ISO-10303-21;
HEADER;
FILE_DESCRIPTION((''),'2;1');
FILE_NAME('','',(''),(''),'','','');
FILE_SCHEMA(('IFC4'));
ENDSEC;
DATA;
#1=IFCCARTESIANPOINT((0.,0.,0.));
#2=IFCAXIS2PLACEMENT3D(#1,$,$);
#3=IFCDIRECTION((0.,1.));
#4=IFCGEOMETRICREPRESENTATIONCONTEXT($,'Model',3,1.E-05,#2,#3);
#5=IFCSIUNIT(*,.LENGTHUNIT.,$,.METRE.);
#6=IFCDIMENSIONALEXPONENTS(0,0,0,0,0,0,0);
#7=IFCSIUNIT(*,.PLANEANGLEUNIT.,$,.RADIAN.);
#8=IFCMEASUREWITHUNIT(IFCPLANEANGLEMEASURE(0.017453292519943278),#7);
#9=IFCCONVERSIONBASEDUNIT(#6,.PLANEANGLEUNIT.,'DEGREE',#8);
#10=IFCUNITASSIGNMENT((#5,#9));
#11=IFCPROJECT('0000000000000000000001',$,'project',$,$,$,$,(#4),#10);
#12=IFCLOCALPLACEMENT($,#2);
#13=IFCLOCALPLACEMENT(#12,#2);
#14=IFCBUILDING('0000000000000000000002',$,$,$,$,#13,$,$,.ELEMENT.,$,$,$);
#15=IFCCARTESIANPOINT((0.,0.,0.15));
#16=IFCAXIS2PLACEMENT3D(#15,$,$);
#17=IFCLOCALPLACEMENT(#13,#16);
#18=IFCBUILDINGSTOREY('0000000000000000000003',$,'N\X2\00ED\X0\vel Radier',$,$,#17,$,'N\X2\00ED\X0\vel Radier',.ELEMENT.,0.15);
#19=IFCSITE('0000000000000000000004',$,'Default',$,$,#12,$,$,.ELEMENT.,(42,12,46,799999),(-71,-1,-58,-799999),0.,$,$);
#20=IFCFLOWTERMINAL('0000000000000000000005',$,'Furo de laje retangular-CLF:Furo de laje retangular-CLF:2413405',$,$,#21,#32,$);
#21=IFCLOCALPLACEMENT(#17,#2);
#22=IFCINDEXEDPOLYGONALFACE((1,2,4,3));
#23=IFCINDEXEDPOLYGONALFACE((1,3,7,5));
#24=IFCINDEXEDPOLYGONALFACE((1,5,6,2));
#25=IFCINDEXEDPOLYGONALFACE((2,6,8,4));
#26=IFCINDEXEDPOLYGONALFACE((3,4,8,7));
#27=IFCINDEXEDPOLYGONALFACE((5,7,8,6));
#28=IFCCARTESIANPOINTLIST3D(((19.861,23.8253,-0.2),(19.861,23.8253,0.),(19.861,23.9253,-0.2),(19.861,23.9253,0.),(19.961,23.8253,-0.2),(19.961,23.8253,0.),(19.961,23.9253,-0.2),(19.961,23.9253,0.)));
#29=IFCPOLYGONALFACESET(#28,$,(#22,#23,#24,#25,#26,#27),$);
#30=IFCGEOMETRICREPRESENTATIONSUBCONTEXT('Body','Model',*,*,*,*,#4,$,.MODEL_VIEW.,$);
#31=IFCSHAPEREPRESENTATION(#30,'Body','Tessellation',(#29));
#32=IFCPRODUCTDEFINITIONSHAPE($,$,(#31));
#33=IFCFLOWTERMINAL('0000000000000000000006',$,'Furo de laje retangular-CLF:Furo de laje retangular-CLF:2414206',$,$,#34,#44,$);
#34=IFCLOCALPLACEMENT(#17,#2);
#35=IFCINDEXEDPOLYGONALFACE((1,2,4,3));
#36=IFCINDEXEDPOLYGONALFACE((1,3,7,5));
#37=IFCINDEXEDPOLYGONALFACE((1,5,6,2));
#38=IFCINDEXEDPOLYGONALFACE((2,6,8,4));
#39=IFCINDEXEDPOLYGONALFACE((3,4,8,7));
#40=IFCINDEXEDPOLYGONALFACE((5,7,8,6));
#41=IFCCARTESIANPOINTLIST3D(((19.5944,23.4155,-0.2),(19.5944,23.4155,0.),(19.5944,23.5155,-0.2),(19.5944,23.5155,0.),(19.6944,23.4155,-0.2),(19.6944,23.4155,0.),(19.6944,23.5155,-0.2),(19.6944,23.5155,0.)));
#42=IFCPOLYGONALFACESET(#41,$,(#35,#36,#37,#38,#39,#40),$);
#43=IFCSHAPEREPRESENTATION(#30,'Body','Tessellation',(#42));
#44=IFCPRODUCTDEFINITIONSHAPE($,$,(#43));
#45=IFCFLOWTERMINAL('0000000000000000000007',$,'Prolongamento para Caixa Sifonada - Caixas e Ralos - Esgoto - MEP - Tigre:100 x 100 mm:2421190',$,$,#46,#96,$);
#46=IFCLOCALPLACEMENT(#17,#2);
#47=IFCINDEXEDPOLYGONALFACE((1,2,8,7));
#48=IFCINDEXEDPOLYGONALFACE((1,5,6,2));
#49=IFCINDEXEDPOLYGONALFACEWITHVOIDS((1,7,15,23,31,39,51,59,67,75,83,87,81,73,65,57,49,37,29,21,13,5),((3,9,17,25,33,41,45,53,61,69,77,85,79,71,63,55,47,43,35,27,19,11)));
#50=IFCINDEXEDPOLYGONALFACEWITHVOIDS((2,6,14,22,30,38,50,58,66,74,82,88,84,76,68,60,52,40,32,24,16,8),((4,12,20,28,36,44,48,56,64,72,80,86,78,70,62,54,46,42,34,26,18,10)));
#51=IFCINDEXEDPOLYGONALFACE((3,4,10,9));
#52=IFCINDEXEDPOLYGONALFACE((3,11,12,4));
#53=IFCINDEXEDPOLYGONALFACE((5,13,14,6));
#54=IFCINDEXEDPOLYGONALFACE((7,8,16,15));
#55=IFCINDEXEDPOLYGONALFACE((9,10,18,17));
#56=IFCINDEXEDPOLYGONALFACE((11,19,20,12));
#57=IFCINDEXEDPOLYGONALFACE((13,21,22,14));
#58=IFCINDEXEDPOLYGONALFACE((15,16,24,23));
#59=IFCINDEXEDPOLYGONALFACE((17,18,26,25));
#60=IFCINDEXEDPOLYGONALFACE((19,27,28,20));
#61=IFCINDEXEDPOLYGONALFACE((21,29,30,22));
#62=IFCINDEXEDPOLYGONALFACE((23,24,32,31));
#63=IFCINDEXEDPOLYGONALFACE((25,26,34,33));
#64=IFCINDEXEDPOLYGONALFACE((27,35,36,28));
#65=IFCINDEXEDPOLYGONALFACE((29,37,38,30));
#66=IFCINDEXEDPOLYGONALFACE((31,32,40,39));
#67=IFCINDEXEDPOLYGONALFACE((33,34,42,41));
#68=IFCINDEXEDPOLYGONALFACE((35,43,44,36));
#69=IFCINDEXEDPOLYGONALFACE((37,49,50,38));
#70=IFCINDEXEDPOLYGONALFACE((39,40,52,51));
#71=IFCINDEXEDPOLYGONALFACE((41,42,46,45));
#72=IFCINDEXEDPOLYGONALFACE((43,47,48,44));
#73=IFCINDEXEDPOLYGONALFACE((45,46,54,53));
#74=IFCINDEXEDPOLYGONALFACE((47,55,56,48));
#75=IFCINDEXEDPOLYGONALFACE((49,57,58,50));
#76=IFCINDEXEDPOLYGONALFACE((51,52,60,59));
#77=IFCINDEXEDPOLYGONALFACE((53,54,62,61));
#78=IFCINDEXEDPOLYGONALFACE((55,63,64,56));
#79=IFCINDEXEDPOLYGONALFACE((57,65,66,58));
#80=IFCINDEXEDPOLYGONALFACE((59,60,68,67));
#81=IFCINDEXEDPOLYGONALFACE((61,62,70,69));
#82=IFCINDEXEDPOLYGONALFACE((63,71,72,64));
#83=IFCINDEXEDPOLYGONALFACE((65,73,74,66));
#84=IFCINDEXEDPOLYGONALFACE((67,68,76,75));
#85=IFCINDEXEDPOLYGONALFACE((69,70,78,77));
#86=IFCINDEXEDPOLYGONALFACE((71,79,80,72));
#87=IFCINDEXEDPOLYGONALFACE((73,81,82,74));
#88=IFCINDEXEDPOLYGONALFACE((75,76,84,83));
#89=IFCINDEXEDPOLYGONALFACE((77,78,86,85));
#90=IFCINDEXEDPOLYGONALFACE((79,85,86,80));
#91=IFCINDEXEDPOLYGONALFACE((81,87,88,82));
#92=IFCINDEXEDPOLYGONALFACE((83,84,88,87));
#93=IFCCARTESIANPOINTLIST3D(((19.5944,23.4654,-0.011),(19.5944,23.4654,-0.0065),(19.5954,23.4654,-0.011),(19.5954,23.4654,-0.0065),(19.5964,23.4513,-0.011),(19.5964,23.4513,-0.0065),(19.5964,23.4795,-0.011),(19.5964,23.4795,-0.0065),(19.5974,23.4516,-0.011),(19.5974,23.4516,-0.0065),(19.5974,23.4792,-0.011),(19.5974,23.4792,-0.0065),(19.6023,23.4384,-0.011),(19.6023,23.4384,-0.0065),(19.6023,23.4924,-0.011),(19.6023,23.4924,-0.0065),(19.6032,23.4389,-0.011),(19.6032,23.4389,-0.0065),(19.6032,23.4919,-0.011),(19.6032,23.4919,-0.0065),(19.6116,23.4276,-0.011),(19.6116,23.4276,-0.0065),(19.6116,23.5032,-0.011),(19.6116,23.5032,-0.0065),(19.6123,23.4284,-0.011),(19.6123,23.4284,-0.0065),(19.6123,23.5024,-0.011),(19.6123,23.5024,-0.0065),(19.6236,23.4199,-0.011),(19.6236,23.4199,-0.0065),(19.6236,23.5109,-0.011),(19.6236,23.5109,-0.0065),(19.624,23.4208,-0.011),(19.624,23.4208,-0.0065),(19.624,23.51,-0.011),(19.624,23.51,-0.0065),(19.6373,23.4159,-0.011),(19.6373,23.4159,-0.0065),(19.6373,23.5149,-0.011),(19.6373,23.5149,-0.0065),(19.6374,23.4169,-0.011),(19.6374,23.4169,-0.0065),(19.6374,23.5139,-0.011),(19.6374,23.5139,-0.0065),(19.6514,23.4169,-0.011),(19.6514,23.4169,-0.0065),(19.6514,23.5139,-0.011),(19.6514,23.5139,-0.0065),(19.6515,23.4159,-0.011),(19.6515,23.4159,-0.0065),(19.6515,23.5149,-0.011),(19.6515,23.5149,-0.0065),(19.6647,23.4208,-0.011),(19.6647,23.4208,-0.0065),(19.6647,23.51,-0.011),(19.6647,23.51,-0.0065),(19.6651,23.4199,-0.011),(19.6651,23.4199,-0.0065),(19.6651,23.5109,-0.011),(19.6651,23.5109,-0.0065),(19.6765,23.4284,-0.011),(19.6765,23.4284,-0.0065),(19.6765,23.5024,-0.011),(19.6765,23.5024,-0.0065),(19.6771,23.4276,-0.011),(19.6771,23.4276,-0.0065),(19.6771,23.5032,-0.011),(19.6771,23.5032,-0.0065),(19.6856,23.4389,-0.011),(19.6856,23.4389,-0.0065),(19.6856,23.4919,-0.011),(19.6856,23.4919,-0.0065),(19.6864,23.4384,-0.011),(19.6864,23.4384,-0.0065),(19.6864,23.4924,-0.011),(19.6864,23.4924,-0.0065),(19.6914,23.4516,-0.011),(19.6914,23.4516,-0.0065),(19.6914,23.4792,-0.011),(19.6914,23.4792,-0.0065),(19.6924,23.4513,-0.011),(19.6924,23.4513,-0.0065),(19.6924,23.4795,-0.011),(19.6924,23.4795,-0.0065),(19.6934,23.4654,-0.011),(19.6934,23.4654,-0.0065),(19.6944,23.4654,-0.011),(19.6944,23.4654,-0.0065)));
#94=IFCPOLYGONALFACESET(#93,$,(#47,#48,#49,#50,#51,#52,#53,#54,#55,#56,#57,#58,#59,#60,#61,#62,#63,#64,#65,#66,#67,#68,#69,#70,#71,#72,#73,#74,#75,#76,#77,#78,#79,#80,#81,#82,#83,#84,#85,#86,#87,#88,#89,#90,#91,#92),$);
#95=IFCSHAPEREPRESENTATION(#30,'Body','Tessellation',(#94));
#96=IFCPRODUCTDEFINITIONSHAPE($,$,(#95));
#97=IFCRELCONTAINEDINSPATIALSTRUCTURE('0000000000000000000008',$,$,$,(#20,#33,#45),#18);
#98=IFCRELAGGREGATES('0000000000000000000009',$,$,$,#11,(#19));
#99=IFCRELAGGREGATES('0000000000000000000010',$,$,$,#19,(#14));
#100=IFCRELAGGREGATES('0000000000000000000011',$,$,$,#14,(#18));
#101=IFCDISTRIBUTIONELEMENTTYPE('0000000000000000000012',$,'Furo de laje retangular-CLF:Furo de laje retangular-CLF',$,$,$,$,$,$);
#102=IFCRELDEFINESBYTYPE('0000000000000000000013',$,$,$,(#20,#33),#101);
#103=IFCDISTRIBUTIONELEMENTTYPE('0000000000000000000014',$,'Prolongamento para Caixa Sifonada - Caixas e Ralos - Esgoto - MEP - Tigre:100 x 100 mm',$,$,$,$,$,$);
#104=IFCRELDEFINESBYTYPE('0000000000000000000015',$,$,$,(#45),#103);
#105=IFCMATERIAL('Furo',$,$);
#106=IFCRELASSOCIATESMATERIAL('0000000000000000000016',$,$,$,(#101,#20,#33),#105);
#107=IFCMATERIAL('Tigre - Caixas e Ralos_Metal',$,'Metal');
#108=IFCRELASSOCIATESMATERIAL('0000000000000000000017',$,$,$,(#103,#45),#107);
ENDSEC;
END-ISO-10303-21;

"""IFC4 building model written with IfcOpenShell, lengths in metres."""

from ifc_helpers import new_model, entity, si_unit, converted_unit, direction, frame, origin, place, context, subcontext, project, spatial, arc, indexed_curve, outline, extrude, source, transform, mapped, material, type_object, type_shapes, element, save


model = new_model("IFC4")

# Units and contexts
model_context = context("Model", 3, precision=1e-05, world=origin(), true_north=direction((0.0, 1.0)))
body_context = subcontext(model_context, "Body", "Model", "MODEL_VIEW")
ifc_project = project(units=[si_unit("LENGTHUNIT", "METRE"), converted_unit("PLANEANGLEUNIT", "DEGREE", entity("IfcPlaneAngleMeasure", 0.017453292519943278), si_unit("PLANEANGLEUNIT", "RADIAN"), dimensions=[0, 0, 0, 0, 0, 0, 0])], contexts=[model_context])

# Site, building, storey
site_placement = place(None, origin())
site = spatial("IfcSite", under=ifc_project, at=site_placement, Name="Default", CompositionType="ELEMENT", RefLatitude=(42, 12, 46, 799999), RefLongitude=(-71, -1, -58, -799999), RefElevation=0.0)
building_placement = place(site_placement, origin())
building = spatial("IfcBuilding", under=site, at=building_placement, CompositionType="ELEMENT")
storey_placement = place(building_placement, frame((0.0, 0.0, 0.15)))
storey = spatial("IfcBuildingStorey", under=building, at=storey_placement, Name="Nível Radier", LongName="Nível Radier", CompositionType="ELEMENT", Elevation=0.15)

# Flow terminals
ifc_material_1 = material(Name="Furo")
distribution_element_type_1 = type_object("IfcDistributionElementType", Name="Furo de laje retangular-CLF:Furo de laje retangular-CLF", material=ifc_material_1)
shared_shape_1 = source(origin(), body_context, "Body", "SweptSolid", [
    extrude(outline(indexed_curve([(-0.05, -0.05), (0.05, -0.05), (0.05, 0.05), (-0.05, 0.05), (-0.05, -0.05)], self_intersect=False)), frame((0.0, 0.0, -0.2), z_axis=(0.0, 0.0, 1.0), x_axis=(0.0, 1.0, 0.0)), (0.0, 0.0, 1.0), 0.2),
])
type_shapes(distribution_element_type_1, [shared_shape_1])
for number, where, z_axis, x_axis, name in (
    (1, (19.911, 23.8753, 0.0), (0.0, 0.0, 1.0), (-1.0, 0.0, 0.0), "Furo de laje retangular-CLF:Furo de laje retangular-CLF:2413405"),
    (2, (19.6444, 23.4655, 0.0), (0.0, 0.0, 1.0), (-1.0, 0.0, 0.0), "Furo de laje retangular-CLF:Furo de laje retangular-CLF:2414206"),
):
    element("IfcFlowTerminal", number, at=place(storey_placement, frame(where, z_axis=z_axis, x_axis=x_axis)), inside=storey, type_object=distribution_element_type_1, material=ifc_material_1, Name=name, context=body_context, shape_type="MappedRepresentation", body=[
        mapped(shared_shape_1, transform((0.0, 0.0, 0.0), scale=1.0)),
    ])
ifc_material_2 = material(Name="Tigre - Caixas e Ralos_Metal", Category="Metal")
distribution_element_type_2 = type_object("IfcDistributionElementType", Name="Prolongamento para Caixa Sifonada - Caixas e Ralos - Esgoto - MEP - Tigre:100 x 100 mm", material=ifc_material_2)
shared_shape_2 = source(origin(), body_context, "Body", "SweptSolid", [
    extrude(outline(indexed_curve([(-0.05, 0.0), (0.0, -0.05), (0.05, 0.0), (0.0, 0.05)], segments=[arc(1, 2, 3), arc(3, 4, 1)], self_intersect=False), holes=[indexed_curve([(-0.049, 0.0), (0.0, 0.049), (0.049, 0.0), (0.0, -0.049)], segments=[arc(1, 2, 3), arc(3, 4, 1)], self_intersect=False)]), frame((0.0, 0.0, -0.0045)), (0.0, 0.0, 1.0), 0.0045),
])
type_shapes(distribution_element_type_2, [shared_shape_2])
flow_terminal_1_placement = place(storey_placement, frame((19.6444, 23.4654, -0.0065)))
element("IfcFlowTerminal", 3, at=flow_terminal_1_placement, inside=storey, type_object=distribution_element_type_2, material=ifc_material_2, Name="Prolongamento para Caixa Sifonada - Caixas e Ralos - Esgoto - MEP - Tigre:100 x 100 mm:2421190", context=body_context, shape_type="MappedRepresentation", body=[
    mapped(shared_shape_2, transform((0.0, 0.0, 0.0), scale=1.0)),
])

save(model, "model.ifc")
